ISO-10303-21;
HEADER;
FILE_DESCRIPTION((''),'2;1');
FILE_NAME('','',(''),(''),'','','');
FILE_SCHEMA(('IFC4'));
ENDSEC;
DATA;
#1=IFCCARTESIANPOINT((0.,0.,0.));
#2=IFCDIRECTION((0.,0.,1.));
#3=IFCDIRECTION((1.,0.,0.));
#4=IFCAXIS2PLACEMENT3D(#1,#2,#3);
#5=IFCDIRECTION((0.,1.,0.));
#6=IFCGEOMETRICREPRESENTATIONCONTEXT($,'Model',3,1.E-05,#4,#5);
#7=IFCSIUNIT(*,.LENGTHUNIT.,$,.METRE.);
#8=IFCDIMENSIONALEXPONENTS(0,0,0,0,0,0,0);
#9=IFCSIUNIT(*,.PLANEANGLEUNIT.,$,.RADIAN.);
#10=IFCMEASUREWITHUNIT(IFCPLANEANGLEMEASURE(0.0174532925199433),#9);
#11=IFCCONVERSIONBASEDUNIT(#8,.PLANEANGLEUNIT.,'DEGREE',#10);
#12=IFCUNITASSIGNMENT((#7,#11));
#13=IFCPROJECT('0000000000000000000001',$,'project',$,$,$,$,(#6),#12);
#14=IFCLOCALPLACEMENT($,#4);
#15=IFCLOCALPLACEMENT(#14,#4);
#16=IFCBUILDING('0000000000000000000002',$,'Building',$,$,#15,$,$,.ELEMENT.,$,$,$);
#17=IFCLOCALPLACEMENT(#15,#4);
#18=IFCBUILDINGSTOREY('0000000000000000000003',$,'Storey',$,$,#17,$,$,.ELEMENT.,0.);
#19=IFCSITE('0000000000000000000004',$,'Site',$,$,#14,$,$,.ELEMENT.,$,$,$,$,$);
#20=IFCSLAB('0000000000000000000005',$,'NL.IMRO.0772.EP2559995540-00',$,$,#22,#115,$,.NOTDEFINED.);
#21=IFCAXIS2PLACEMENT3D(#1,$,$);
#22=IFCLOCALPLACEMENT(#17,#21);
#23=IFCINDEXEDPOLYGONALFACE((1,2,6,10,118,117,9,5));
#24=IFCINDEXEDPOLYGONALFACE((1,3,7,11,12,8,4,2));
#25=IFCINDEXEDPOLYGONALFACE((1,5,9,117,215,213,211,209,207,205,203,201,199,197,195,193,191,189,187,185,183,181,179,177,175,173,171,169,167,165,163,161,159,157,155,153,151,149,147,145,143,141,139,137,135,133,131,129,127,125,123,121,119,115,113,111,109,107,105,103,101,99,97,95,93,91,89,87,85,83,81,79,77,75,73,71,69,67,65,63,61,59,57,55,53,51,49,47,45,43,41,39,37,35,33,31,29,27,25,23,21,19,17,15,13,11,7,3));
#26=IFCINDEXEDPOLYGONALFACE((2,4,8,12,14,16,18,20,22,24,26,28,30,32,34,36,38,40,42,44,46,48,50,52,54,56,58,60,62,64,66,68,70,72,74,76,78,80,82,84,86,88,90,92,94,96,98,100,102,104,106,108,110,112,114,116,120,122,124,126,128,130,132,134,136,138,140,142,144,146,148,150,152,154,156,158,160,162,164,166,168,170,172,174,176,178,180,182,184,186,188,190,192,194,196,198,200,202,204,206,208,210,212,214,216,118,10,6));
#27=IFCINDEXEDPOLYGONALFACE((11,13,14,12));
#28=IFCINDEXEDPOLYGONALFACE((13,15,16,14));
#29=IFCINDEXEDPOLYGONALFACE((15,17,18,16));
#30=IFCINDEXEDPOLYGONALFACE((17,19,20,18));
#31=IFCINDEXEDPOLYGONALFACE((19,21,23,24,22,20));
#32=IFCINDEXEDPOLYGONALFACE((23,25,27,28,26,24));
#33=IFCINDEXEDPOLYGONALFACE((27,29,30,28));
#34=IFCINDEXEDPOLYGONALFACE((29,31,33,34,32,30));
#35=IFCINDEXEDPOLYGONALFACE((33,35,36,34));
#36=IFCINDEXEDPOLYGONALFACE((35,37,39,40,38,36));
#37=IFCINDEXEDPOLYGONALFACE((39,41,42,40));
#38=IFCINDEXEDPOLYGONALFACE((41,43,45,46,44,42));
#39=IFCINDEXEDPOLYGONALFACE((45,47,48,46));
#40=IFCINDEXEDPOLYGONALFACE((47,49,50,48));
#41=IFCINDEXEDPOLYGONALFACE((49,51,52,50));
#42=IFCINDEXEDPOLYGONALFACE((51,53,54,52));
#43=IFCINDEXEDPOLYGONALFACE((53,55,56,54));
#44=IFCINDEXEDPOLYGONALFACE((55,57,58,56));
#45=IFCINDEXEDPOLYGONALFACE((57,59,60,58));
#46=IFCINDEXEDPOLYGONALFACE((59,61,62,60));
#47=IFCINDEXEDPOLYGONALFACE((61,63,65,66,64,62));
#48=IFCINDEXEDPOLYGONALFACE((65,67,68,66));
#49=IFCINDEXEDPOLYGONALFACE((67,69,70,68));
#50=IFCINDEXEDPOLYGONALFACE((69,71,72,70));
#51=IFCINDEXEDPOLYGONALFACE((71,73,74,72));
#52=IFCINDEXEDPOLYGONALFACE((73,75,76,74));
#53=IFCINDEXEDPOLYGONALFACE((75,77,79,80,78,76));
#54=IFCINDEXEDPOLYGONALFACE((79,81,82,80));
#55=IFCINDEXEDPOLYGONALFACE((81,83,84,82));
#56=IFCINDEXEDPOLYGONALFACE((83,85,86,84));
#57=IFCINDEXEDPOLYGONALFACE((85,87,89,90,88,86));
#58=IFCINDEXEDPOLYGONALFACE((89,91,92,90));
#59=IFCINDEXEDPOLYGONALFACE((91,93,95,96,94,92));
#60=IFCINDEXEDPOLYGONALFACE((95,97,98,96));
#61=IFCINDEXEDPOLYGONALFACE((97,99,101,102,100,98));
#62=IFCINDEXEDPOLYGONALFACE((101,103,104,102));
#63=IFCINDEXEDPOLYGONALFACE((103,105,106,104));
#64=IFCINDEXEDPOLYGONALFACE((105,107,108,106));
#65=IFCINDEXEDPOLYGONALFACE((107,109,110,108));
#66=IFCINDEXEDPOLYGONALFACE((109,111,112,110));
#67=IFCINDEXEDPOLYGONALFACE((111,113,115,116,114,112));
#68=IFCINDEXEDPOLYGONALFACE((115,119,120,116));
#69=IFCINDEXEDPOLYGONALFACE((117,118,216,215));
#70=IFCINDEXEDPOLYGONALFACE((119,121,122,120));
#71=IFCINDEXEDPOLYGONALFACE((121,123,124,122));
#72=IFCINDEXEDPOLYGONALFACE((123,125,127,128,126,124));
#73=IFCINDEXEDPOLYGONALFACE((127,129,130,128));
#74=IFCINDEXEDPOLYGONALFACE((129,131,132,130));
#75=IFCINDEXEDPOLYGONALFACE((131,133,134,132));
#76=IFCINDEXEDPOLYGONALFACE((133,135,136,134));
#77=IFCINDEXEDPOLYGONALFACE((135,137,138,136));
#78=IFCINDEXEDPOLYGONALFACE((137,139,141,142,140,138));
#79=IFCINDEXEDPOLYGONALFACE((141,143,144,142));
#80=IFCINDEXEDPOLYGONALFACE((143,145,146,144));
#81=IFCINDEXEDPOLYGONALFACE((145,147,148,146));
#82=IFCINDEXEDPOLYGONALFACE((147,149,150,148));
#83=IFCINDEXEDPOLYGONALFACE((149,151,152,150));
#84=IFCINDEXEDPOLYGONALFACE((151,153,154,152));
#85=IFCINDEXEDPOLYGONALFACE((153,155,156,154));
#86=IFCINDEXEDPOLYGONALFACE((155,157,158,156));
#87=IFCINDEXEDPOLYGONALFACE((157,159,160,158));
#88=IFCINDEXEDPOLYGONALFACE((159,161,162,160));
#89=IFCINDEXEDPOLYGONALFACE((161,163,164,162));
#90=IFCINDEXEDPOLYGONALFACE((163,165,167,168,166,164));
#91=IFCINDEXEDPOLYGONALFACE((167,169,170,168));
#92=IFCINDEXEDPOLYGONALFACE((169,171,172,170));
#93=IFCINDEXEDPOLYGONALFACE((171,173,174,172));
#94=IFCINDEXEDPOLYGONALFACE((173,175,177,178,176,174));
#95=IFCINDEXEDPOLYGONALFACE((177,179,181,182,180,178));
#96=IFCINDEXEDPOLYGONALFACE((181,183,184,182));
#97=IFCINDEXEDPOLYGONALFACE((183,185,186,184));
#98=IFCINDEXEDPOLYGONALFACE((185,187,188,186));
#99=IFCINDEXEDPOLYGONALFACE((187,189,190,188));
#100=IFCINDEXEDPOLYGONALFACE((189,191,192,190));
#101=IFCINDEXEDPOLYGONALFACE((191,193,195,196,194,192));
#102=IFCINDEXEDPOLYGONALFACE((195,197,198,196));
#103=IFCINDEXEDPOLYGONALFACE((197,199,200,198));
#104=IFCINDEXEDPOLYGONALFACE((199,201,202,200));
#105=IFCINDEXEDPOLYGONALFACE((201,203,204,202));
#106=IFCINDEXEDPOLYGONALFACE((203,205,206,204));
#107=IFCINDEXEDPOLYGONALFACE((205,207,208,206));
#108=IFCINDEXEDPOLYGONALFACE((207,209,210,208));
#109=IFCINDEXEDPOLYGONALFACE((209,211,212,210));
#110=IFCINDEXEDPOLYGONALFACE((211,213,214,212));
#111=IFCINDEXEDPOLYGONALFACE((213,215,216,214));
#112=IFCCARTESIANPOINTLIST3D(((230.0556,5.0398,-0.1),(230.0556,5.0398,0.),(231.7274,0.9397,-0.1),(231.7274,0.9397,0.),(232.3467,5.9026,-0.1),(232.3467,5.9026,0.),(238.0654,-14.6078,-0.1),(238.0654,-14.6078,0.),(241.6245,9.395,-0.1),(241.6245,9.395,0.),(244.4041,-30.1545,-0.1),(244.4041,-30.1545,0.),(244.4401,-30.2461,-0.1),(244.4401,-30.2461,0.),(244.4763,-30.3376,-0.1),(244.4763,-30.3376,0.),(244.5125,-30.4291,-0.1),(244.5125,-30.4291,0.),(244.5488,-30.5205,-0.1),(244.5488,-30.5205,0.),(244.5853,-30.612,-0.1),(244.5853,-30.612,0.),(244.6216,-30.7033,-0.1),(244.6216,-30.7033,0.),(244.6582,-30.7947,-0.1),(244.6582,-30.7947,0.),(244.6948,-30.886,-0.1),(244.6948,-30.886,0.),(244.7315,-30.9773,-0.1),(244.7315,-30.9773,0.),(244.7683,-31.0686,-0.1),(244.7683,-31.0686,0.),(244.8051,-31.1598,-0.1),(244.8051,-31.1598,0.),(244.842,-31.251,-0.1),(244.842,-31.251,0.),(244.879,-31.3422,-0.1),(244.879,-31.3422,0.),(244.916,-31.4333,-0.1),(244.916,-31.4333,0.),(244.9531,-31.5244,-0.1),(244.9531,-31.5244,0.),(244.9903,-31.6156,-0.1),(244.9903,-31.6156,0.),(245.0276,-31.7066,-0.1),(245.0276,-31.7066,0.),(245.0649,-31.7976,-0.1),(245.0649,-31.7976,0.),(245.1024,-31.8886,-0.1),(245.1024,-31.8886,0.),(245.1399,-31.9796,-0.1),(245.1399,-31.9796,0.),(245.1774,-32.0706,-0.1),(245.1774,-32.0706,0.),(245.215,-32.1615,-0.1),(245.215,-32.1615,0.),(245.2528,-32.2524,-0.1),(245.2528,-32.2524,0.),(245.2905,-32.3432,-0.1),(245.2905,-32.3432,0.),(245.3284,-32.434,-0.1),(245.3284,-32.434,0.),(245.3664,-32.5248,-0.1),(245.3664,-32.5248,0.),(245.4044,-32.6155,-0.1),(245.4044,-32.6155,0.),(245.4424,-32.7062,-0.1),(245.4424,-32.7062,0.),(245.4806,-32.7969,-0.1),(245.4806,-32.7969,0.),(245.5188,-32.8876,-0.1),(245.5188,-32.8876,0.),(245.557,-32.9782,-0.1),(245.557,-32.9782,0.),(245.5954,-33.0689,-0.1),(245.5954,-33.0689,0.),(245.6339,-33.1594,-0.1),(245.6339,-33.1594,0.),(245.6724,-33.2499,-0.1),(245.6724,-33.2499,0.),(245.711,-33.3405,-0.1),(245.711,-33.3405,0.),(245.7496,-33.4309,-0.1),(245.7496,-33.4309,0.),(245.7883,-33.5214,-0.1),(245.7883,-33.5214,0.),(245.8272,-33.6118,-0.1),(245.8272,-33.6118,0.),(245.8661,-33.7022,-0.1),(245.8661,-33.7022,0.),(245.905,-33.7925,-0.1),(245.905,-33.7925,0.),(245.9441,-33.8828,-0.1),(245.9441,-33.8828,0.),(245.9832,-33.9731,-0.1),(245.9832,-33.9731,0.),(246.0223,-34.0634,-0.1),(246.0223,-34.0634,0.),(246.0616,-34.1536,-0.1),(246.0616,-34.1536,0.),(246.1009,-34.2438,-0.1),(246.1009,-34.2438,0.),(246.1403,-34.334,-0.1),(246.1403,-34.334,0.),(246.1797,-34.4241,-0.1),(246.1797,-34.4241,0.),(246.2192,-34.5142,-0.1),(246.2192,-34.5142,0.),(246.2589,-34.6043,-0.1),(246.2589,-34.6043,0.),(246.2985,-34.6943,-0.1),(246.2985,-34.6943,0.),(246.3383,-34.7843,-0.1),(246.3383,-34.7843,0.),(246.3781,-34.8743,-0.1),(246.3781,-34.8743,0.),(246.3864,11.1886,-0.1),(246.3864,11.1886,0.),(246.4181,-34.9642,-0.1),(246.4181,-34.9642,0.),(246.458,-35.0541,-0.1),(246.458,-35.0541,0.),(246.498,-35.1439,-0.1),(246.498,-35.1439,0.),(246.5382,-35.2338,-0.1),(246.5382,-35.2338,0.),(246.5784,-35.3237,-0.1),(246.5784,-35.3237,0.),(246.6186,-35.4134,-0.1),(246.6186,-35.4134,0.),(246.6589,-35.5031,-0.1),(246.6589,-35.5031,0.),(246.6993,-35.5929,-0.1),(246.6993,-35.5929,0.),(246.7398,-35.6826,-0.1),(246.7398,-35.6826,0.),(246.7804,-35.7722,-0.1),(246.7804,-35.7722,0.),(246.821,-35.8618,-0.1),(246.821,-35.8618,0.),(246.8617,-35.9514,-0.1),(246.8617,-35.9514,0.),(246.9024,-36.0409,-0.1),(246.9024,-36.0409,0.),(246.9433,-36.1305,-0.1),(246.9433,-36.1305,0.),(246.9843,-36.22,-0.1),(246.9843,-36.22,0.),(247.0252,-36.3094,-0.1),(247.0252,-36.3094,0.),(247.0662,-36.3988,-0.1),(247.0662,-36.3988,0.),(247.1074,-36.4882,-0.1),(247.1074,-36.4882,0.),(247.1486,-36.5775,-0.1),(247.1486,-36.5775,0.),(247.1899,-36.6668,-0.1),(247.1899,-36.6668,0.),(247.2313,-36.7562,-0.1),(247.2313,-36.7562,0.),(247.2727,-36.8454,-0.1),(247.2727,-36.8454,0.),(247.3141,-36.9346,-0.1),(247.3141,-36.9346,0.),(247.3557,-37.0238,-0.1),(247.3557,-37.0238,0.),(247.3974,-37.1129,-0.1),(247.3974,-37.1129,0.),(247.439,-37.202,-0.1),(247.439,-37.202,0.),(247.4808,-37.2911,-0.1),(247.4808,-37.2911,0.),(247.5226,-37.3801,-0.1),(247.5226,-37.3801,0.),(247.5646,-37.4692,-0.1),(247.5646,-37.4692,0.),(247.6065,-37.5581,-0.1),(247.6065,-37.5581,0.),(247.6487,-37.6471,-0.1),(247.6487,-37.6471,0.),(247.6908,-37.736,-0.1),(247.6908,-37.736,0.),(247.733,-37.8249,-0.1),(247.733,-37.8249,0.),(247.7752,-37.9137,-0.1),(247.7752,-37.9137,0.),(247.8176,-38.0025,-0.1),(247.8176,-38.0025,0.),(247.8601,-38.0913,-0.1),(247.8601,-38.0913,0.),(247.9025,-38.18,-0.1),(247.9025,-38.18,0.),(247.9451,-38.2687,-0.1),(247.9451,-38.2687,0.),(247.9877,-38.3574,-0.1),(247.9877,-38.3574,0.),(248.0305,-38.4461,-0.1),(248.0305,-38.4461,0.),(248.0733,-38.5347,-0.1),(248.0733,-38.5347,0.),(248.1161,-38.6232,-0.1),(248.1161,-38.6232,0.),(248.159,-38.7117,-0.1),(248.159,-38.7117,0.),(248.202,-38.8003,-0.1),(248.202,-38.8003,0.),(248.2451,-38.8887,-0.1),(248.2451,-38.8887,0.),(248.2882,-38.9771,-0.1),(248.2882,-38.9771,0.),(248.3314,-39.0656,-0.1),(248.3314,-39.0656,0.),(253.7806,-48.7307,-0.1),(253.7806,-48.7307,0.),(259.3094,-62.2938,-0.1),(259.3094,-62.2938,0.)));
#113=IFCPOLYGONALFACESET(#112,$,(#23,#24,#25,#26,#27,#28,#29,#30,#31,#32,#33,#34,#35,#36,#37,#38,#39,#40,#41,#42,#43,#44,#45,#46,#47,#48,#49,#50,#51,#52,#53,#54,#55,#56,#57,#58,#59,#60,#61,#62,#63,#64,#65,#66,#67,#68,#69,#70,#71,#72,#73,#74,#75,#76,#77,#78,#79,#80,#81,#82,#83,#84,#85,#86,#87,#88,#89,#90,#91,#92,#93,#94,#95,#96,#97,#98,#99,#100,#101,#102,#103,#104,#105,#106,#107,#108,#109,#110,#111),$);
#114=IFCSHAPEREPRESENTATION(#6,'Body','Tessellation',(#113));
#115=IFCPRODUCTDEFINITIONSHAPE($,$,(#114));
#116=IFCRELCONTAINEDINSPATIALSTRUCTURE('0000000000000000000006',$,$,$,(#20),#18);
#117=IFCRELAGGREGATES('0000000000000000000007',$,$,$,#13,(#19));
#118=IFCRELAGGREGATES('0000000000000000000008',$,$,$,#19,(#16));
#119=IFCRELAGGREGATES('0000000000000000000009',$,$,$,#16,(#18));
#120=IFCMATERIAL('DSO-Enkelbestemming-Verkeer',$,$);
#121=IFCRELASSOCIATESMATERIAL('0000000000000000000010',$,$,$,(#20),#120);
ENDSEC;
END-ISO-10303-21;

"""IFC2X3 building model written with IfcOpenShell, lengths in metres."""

from ifc_helpers import new_model, entity, si_unit, converted_unit, direction, frame, origin_with_axes, place, context, project, spatial, polyline, outline, extrude, material, element, save


model = new_model("IFC2X3")

# Units and contexts
model_context = context("Model", 3, precision=1e-05, world=origin_with_axes(), true_north=direction((0.0, 1.0, 0.0)))
ifc_project = project(units=[si_unit("LENGTHUNIT", "METRE"), converted_unit("PLANEANGLEUNIT", "DEGREE", entity("IfcPlaneAngleMeasure", 0.0174532925199433), si_unit("PLANEANGLEUNIT", "RADIAN"), dimensions=[0, 0, 0, 0, 0, 0, 0])], contexts=[model_context])

# Site, building, storey
site_placement = place(None, origin_with_axes())
site = spatial("IfcSite", under=ifc_project, at=site_placement, Name="Site", CompositionType="ELEMENT")
building_placement = place(site_placement, origin_with_axes())
building = spatial("IfcBuilding", under=site, at=building_placement, Name="Building", CompositionType="ELEMENT")
storey_placement = place(building_placement, origin_with_axes())
storey = spatial("IfcBuildingStorey", under=building, at=storey_placement, Name="Storey", CompositionType="ELEMENT", Elevation=0.0)

# Slab
ifc_material_1 = material(Name="DSO-Enkelbestemming-Verkeer")
slab_1_placement = place(storey_placement, frame((0.0, 0.0, -0.1), z_axis=(0.0, 0.0, 1.0), x_axis=(1.0, 0.0, 0.0)))
element("IfcSlab", 1, at=slab_1_placement, inside=storey, material=ifc_material_1, Name="NL.IMRO.0772.EP2559995540-00", PredefinedType="NOTDEFINED", context=model_context, shape_type="SweptSolid", body=[
    extrude(outline(polyline([(238.0654, -14.6078), (231.7274, 0.9397), (230.0556, 5.0398), (232.3467, 5.9026), (241.6245, 9.395), (246.3864, 11.1886), (259.3094, -62.2938), (253.7806, -48.7307), (248.3314, -39.0656), (248.2882, -38.9771), (248.2451, -38.8887), (248.202, -38.8003), (248.159, -38.7117), (248.1161, -38.6232), (248.0733, -38.5347), (248.0305, -38.4461), (247.9877, -38.3574), (247.9451, -38.2687), (247.9025, -38.18), (247.8601, -38.0913), (247.8176, -38.0025), (247.7752, -37.9137), (247.733, -37.8249), (247.6908, -37.736), (247.6487, -37.6471), (247.6065, -37.5581), (247.5646, -37.4692), (247.5226, -37.3801), (247.4808, -37.2911), (247.439, -37.202), (247.3974, -37.1129), (247.3557, -37.0238), (247.3141, -36.9346), (247.2727, -36.8454), (247.2313, -36.7562), (247.1899, -36.6668), (247.1486, -36.5775), (247.1074, -36.4882), (247.0662, -36.3988), (247.0252, -36.3094), (246.9843, -36.22), (246.9433, -36.1305), (246.9024, -36.0409), (246.8617, -35.9514), (246.821, -35.8618), (246.7804, -35.7722), (246.7398, -35.6826), (246.6993, -35.5929), (246.6589, -35.5031), (246.6186, -35.4134), (246.5784, -35.3237), (246.5382, -35.2338), (246.498, -35.1439), (246.458, -35.0541), (246.4181, -34.9642), (246.3781, -34.8743), (246.3383, -34.7843), (246.2985, -34.6943), (246.2589, -34.6043), (246.2192, -34.5142), (246.1797, -34.4241), (246.1403, -34.334), (246.1009, -34.2438), (246.0616, -34.1536), (246.0223, -34.0634), (245.9832, -33.9731), (245.9441, -33.8828), (245.905, -33.7925), (245.8661, -33.7022), (245.8272, -33.6118), (245.7883, -33.5214), (245.7496, -33.4309), (245.711, -33.3405), (245.6724, -33.2499), (245.6339, -33.1594), (245.5954, -33.0689), (245.557, -32.9782), (245.5188, -32.8876), (245.4806, -32.7969), (245.4424, -32.7062), (245.4044, -32.6155), (245.3664, -32.5248), (245.3284, -32.434), (245.2905, -32.3432), (245.2528, -32.2524), (245.215, -32.1615), (245.1774, -32.0706), (245.1399, -31.9796), (245.1024, -31.8886), (245.0649, -31.7976), (245.0276, -31.7066), (244.9903, -31.6156), (244.9531, -31.5244), (244.916, -31.4333), (244.879, -31.3422), (244.842, -31.251), (244.8051, -31.1598), (244.7683, -31.0686), (244.7315, -30.9773), (244.6948, -30.886), (244.6582, -30.7947), (244.6216, -30.7033), (244.5853, -30.612), (244.5488, -30.5205), (244.5125, -30.4291), (244.4763, -30.3376), (244.4401, -30.2461), (244.4041, -30.1545), (238.0654, -14.6078)])), origin_with_axes(), (0.0, 0.0, 1.0), 0.1),
])

save(model, "model.ifc")
